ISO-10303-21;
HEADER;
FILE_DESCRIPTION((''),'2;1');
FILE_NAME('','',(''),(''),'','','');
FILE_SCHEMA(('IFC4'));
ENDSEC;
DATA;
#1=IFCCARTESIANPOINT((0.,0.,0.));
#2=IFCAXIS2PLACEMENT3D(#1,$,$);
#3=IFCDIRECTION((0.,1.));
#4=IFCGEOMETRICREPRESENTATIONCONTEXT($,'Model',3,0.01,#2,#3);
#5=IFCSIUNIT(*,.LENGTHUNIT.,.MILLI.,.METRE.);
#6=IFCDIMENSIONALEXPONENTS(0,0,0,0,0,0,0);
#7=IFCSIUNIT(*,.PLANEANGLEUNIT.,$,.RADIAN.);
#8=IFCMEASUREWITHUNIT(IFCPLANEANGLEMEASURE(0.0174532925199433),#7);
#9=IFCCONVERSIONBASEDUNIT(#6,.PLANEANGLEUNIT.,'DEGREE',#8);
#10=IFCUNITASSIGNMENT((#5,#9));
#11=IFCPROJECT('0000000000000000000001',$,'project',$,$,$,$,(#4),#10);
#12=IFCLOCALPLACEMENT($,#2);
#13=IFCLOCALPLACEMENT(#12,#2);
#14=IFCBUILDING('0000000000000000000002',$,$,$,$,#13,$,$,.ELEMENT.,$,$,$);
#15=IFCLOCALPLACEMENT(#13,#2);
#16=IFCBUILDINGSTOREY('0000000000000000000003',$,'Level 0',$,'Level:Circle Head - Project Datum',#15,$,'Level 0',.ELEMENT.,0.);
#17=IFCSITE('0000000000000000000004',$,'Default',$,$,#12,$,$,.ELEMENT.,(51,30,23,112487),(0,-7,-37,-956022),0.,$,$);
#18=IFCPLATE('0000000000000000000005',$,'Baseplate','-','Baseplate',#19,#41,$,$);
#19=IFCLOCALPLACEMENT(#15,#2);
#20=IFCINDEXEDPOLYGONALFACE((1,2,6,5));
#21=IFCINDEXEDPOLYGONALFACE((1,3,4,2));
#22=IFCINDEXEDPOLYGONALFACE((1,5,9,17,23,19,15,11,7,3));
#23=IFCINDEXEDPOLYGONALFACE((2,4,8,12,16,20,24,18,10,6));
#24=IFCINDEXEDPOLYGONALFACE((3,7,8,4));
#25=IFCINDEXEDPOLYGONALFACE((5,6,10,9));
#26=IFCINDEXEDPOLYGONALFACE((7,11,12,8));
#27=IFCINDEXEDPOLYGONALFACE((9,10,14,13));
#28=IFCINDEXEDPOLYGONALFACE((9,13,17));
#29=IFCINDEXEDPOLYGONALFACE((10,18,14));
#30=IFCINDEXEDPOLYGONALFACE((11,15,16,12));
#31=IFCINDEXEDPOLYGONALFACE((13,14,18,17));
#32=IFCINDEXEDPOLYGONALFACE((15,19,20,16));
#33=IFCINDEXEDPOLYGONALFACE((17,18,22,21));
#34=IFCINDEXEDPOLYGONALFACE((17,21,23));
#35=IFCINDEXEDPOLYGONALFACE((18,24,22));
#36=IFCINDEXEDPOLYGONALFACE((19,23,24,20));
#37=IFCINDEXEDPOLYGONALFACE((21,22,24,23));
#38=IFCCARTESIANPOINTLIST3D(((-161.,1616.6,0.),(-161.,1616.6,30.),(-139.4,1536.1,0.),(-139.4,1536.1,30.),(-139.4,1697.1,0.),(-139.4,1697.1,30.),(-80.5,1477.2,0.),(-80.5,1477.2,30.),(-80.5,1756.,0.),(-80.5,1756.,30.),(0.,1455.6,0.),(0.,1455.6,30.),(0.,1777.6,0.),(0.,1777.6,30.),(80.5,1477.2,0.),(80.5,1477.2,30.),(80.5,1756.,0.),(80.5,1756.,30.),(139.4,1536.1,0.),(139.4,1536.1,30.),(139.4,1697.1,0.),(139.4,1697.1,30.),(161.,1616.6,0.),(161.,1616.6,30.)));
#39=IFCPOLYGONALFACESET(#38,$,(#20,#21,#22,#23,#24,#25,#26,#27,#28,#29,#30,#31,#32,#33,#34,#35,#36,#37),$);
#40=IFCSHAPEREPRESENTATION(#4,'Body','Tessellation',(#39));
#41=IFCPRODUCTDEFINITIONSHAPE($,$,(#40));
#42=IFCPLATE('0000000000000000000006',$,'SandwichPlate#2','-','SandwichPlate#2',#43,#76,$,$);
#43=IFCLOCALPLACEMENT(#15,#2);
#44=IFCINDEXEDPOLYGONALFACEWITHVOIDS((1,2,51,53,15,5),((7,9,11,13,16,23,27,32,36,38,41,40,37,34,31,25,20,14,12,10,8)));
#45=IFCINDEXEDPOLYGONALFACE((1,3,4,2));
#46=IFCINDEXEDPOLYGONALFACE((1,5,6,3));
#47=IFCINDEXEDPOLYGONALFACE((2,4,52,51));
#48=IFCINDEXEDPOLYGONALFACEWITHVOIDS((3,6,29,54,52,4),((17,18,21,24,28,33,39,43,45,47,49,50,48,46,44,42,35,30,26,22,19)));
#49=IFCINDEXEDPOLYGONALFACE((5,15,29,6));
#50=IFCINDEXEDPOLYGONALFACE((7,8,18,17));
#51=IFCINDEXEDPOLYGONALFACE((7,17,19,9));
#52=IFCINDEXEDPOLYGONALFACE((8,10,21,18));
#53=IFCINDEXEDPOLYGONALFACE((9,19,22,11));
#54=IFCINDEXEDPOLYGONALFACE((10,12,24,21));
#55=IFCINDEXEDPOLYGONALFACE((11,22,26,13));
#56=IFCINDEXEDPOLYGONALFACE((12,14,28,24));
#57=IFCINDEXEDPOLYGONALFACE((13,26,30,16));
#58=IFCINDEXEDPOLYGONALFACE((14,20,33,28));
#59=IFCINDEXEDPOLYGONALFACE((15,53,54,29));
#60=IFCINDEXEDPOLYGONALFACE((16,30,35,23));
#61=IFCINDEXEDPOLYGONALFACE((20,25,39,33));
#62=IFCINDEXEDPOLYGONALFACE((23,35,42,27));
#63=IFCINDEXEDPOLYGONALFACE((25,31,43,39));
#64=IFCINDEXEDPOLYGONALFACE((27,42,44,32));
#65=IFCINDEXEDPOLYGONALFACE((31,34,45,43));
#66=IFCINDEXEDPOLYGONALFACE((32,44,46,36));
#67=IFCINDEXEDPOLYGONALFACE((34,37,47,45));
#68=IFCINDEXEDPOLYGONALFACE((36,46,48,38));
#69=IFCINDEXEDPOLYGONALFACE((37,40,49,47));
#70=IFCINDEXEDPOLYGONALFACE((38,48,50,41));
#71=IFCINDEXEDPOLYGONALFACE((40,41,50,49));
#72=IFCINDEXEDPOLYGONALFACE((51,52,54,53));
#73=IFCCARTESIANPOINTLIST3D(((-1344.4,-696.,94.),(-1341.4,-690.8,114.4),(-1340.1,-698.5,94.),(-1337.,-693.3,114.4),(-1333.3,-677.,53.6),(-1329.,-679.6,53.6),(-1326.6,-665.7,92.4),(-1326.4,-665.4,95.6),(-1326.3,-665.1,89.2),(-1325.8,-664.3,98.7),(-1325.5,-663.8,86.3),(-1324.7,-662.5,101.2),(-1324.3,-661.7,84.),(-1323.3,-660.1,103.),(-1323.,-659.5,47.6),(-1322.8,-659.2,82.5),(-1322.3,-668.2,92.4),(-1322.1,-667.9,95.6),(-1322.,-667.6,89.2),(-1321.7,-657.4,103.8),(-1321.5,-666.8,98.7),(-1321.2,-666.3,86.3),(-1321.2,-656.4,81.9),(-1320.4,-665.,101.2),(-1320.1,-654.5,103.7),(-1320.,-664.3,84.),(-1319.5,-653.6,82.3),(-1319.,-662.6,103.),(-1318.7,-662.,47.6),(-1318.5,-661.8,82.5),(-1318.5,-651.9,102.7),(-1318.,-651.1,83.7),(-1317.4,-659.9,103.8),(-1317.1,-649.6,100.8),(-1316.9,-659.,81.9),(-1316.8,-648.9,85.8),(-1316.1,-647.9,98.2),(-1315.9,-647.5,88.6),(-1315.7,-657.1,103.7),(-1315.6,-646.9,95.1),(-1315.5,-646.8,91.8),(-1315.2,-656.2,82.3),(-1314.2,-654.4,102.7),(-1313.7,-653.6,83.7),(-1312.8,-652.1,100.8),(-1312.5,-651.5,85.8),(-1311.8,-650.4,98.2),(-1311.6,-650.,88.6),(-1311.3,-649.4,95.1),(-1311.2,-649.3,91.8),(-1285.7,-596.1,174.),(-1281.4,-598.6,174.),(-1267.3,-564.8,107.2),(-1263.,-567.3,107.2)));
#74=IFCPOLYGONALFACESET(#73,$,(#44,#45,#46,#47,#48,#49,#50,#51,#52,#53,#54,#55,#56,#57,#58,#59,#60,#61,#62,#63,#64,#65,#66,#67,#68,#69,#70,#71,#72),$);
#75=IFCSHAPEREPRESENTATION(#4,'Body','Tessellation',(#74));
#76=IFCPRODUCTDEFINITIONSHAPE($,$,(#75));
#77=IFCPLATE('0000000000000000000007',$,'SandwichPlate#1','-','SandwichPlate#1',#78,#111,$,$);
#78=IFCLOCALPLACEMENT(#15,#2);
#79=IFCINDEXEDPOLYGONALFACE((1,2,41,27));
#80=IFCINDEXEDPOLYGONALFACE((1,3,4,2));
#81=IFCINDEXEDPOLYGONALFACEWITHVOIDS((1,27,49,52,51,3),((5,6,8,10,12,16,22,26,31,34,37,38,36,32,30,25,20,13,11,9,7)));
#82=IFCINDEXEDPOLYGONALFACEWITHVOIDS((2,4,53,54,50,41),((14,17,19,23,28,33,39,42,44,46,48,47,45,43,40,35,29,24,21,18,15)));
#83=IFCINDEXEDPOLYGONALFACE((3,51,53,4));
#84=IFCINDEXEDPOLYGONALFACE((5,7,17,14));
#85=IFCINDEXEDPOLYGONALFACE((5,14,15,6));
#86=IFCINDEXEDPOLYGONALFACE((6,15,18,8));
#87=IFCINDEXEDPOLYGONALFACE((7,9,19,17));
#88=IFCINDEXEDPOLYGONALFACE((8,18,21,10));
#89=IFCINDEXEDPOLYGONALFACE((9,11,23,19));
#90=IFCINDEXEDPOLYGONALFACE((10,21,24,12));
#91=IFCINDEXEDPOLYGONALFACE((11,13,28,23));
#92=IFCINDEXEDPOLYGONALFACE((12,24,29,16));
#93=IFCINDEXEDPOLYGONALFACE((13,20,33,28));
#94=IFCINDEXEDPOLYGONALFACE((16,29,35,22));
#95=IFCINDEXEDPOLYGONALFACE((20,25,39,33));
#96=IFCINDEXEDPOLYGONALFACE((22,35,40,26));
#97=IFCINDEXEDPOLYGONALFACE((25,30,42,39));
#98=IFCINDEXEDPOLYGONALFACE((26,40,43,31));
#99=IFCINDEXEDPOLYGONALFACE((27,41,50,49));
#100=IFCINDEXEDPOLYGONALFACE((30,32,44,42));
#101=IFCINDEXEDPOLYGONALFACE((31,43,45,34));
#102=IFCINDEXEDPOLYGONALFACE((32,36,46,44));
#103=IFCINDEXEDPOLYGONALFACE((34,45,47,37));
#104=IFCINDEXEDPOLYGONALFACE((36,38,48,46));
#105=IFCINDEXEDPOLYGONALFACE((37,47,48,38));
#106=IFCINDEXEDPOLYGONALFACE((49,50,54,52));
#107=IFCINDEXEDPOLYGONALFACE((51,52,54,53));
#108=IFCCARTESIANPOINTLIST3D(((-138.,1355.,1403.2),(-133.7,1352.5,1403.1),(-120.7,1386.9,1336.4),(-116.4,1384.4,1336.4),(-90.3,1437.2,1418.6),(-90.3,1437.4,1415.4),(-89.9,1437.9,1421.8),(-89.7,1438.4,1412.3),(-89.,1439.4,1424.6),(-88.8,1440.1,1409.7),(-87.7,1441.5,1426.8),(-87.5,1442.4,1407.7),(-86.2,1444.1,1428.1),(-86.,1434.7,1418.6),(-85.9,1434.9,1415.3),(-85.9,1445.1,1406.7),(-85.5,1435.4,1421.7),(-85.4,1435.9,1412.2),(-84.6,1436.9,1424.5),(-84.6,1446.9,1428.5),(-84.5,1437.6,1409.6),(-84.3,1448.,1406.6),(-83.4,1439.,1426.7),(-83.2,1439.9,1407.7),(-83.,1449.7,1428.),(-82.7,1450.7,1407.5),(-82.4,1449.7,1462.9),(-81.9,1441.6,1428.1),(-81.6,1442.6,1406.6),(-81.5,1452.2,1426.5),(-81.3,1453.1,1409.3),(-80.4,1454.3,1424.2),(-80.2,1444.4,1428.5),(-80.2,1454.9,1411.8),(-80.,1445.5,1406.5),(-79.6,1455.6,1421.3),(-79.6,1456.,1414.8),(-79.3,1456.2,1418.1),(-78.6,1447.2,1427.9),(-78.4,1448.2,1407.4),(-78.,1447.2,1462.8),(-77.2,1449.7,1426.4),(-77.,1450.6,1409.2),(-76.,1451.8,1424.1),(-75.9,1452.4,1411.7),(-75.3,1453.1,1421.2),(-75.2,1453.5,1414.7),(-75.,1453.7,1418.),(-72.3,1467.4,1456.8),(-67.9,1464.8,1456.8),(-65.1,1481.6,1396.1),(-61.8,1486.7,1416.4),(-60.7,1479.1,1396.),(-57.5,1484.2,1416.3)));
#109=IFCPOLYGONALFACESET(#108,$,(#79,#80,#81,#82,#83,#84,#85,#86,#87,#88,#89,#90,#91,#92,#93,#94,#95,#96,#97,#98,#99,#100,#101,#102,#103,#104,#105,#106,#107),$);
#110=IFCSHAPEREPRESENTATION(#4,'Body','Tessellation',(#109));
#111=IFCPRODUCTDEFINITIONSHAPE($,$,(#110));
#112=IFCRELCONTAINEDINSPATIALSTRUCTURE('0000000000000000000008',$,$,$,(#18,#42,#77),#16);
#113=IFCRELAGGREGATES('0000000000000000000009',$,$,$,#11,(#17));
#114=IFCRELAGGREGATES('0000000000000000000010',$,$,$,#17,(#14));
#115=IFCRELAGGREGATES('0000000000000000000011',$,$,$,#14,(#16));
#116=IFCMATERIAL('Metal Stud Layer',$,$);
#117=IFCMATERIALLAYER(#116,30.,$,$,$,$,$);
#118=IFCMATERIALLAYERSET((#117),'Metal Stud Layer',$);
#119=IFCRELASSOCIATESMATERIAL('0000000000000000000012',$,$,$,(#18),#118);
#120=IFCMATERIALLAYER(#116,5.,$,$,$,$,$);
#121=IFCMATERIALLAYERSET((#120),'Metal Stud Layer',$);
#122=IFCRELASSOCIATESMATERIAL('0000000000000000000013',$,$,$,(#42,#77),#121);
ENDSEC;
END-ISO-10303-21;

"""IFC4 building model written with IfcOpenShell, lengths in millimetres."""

from ifc_helpers import new_model, entity, si_unit, converted_unit, point, direction, frame, frame_2d, origin, origin_with_axes, origin_2d_with_axis, place, context, project, spatial, polyline, circle_curve, line_curve, trimmed, segment, composite_curve, circle, outline, extrude, material, layer, layer_set, element, save


model = new_model("IFC4")

# Units and contexts
model_context = context("Model", 3, precision=0.01, world=origin(), true_north=direction((0.0, 1.0)))
ifc_project = project(units=[si_unit("LENGTHUNIT", "METRE", prefix="MILLI"), converted_unit("PLANEANGLEUNIT", "DEGREE", entity("IfcPlaneAngleMeasure", 0.0174532925199433), si_unit("PLANEANGLEUNIT", "RADIAN"), dimensions=[0, 0, 0, 0, 0, 0, 0])], contexts=[model_context])

# Site, building, storey
site_placement = place(None, origin())
site = spatial("IfcSite", under=ifc_project, at=site_placement, Name="Default", CompositionType="ELEMENT", RefLatitude=(51, 30, 23, 112487), RefLongitude=(0, -7, -37, -956022), RefElevation=0.0)
building_placement = place(site_placement, origin())
building = spatial("IfcBuilding", under=site, at=building_placement, CompositionType="ELEMENT")
storey_placement = place(building_placement, origin())
storey = spatial("IfcBuildingStorey", under=building, at=storey_placement, Name="Level 0", ObjectType="Level:Circle Head - Project Datum", LongName="Level 0", CompositionType="ELEMENT", Elevation=0.0)

# Plate, openings
ifc_material_1 = material(Name="Metal Stud Layer")
ifc_layer_1 = layer(ifc_material_1, 30.0)
ifc_layer_set_1 = layer_set([ifc_layer_1], Name="Metal Stud Layer")
plate_1_placement = place(storey_placement, frame((-161.0, 1616.6, 30.0), z_axis=(0.0, 0.0, -1.0), x_axis=(0.0, 1.0, 0.0)))
plate_1 = element("IfcPlate", 1, at=plate_1_placement, inside=storey, material=ifc_layer_set_1, Name="Baseplate", Description="-", ObjectType="Baseplate", context=model_context, shape_type="SweptSolid", body=[
    extrude(outline(polyline([(161.0, 0.0), (161.0, 322.0), (-161.0, 322.0), (-161.0, 0.0), (161.0, 0.0)])), origin_with_axes(), (0.0, 0.0, 1.0), 30.0),
])
opening_1_placement = place(plate_1_placement, frame((0.0, 0.0, 0.0), z_axis=(0.0, 0.0, 1.0), x_axis=(1.0, 0.0, 0.0)))
element("IfcOpeningElement", 2, at=opening_1_placement, cuts=plate_1, ObjectType="Opening", context=model_context, shape_type="SweptSolid", body=[
    extrude(outline(composite_curve([segment(trimmed(line_curve((161.0, 0.0), (0.0, 1.0), 161.0), [point((161.0, 0.0))], [point((161.0, 161.0))], True, "CARTESIAN"), True, "CONTINUOUS"), segment(trimmed(circle_curve(frame_2d((0.0, 161.0), x_axis=(-1.0, 0.0)), 161.0), [point((161.0, 161.0))], [point((0.0, 0.0))], False, "CARTESIAN"), True, "CONTINUOUS"), segment(trimmed(line_curve((0.0, 0.0), (1.0, 0.0), 161.0), [point((0.0, 0.0))], [point((161.0, 0.0))], True, "CARTESIAN"), True, "CONTINUOUS")], self_intersect="UNKNOWN")), origin(), (0.0, 0.0, 1.0), 30.0),
])
opening_2_placement = place(plate_1_placement, frame((0.0, 0.0, 0.0), z_axis=(0.0, 0.0, 1.0), x_axis=(1.0, 0.0, 0.0)))
element("IfcOpeningElement", 3, at=opening_2_placement, cuts=plate_1, ObjectType="Opening", context=model_context, shape_type="SweptSolid", body=[
    extrude(outline(composite_curve([segment(trimmed(line_curve((161.0, 322.0), (-1.0, 0.0), 161.0), [point((161.0, 322.0))], [point((0.0, 322.0))], True, "CARTESIAN"), True, "CONTINUOUS"), segment(trimmed(circle_curve(frame_2d((0.0, 161.0), x_axis=(-1.0, 0.0)), 161.0), [point((0.0, 322.0))], [point((161.0, 161.0))], False, "CARTESIAN"), True, "CONTINUOUS"), segment(trimmed(line_curve((161.0, 161.0), (0.0, 1.0), 161.0), [point((161.0, 161.0))], [point((161.0, 322.0))], True, "CARTESIAN"), True, "CONTINUOUS")], self_intersect="UNKNOWN")), origin(), (0.0, 0.0, 1.0), 30.0),
])
opening_3_placement = place(plate_1_placement, frame((0.0, 0.0, 0.0), z_axis=(0.0, 0.0, 1.0), x_axis=(1.0, 0.0, 0.0)))
element("IfcOpeningElement", 4, at=opening_3_placement, cuts=plate_1, ObjectType="Opening", context=model_context, shape_type="SweptSolid", body=[
    extrude(outline(composite_curve([segment(trimmed(line_curve((-161.0, 322.0), (0.0, -1.0), 161.0), [point((-161.0, 322.0))], [point((-161.0, 161.0))], True, "CARTESIAN"), True, "CONTINUOUS"), segment(trimmed(circle_curve(frame_2d((0.0, 161.0), x_axis=(-1.0, 0.0)), 161.0), [point((-161.0, 161.0))], [point((0.0, 322.0))], False, "CARTESIAN"), True, "CONTINUOUS"), segment(trimmed(line_curve((0.0, 322.0), (-1.0, 0.0), 161.0), [point((0.0, 322.0))], [point((-161.0, 322.0))], True, "CARTESIAN"), True, "CONTINUOUS")], self_intersect="UNKNOWN")), origin(), (0.0, 0.0, 1.0), 30.0),
])
opening_4_placement = place(plate_1_placement, frame((0.0, 0.0, 0.0), z_axis=(0.0, 0.0, 1.0), x_axis=(1.0, 0.0, 0.0)))
element("IfcOpeningElement", 5, at=opening_4_placement, cuts=plate_1, ObjectType="Opening", context=model_context, shape_type="SweptSolid", body=[
    extrude(outline(composite_curve([segment(trimmed(line_curve((-161.0, 0.0), (1.0, 0.0), 161.0), [point((-161.0, 0.0))], [point((0.0, 0.0))], True, "CARTESIAN"), True, "CONTINUOUS"), segment(trimmed(circle_curve(frame_2d((0.0, 161.0), x_axis=(-1.0, 0.0)), 161.0), [point((0.0, 0.0))], [point((-161.0, 161.0))], False, "CARTESIAN"), True, "CONTINUOUS"), segment(trimmed(line_curve((-161.0, 161.0), (0.0, -1.0), 161.0), [point((-161.0, 161.0))], [point((-161.0, 0.0))], True, "CARTESIAN"), True, "CONTINUOUS")], self_intersect="UNKNOWN")), origin(), (0.0, 0.0, 1.0), 30.0),
])

# Plate, opening
ifc_layer_2 = layer(ifc_material_1, 5.0)
ifc_layer_set_2 = layer_set([ifc_layer_2], Name="Metal Stud Layer")
plate_2_placement = place(storey_placement, frame((-1348.0, -702.1, 107.2), z_axis=(0.86208, -0.506772, 0.0), x_axis=(0.24181, 0.411348, -0.878818)))
plate_2 = element("IfcPlate", 6, at=plate_2_placement, inside=storey, material=ifc_layer_set_2, Name="SandwichPlate#2", Description="-", ObjectType="SandwichPlate#2", context=model_context, shape_type="SweptSolid", body=[
    extrude(outline(polyline([(15.0, 0.0), (61.0, 0.0), (76.0, 15.0), (76.0, 140.0), (0.0, 140.0), (0.0, 15.0), (15.0, 0.0)])), origin_with_axes(), (0.0, 0.0, 1.0), 5.0),
])
opening_5_placement = place(plate_2_placement, frame((38.0, 40.0, -0.5), z_axis=(0.0, 0.0, 1.0), x_axis=(0.0, 1.0, 0.0)))
element("IfcOpeningElement", 7, at=opening_5_placement, cuts=plate_2, ObjectType="Opening", context=model_context, shape_type="SweptSolid", body=[
    extrude(circle(Radius=11.0, at=origin_2d_with_axis()), origin(), (0.0, 0.0, 1.0), 6.0),
])

# Plate, openings
plate_3_placement = place(storey_placement, frame((-58.4, 1493.0, 1403.2), z_axis=(0.865935, -0.499948, -0.014432), x_axis=(-0.22762, -0.419615, 0.878699)))
plate_3 = element("IfcPlate", 8, at=plate_3_placement, inside=storey, material=ifc_layer_set_2, Name="SandwichPlate#1", Description="-", ObjectType="SandwichPlate#1", context=model_context, shape_type="SweptSolid", body=[
    extrude(outline(polyline([(0.0, 0.0), (76.0, 0.0), (76.0, 140.0), (0.0, 140.0), (0.0, 0.0)])), origin_with_axes(), (0.0, 0.0, 1.0), 5.0),
])
opening_6_placement = place(plate_3_placement, frame((0.0, 0.0, 0.0), z_axis=(0.0, 0.0, 1.0), x_axis=(1.0, 0.0, 0.0)))
element("IfcOpeningElement", 9, at=opening_6_placement, cuts=plate_3, ObjectType="Opening", context=model_context, shape_type="SweptSolid", body=[
    extrude(outline(polyline([(0.0, 0.0), (15.0, 0.0), (0.0, 15.0), (0.0, 0.0)])), origin(), (0.0, 0.0, 1.0), 5.0),
])
opening_7_placement = place(plate_3_placement, frame((0.0, 0.0, 0.0), z_axis=(0.0, 0.0, 1.0), x_axis=(1.0, 0.0, 0.0)))
element("IfcOpeningElement", 10, at=opening_7_placement, cuts=plate_3, ObjectType="Opening", context=model_context, shape_type="SweptSolid", body=[
    extrude(outline(polyline([(76.0, 0.0), (76.0, 15.0), (61.0, 0.0), (76.0, 0.0)])), origin(), (0.0, 0.0, 1.0), 5.0),
])
opening_8_placement = place(plate_3_placement, frame((38.0, 40.0, -0.5), z_axis=(0.0, 0.0, 1.0), x_axis=(0.0, 1.0, 0.0)))
element("IfcOpeningElement", 11, at=opening_8_placement, cuts=plate_3, ObjectType="Opening", context=model_context, shape_type="SweptSolid", body=[
    extrude(circle(Radius=11.0, at=origin_2d_with_axis()), origin(), (0.0, 0.0, 1.0), 6.0),
])

save(model, "model.ifc")
